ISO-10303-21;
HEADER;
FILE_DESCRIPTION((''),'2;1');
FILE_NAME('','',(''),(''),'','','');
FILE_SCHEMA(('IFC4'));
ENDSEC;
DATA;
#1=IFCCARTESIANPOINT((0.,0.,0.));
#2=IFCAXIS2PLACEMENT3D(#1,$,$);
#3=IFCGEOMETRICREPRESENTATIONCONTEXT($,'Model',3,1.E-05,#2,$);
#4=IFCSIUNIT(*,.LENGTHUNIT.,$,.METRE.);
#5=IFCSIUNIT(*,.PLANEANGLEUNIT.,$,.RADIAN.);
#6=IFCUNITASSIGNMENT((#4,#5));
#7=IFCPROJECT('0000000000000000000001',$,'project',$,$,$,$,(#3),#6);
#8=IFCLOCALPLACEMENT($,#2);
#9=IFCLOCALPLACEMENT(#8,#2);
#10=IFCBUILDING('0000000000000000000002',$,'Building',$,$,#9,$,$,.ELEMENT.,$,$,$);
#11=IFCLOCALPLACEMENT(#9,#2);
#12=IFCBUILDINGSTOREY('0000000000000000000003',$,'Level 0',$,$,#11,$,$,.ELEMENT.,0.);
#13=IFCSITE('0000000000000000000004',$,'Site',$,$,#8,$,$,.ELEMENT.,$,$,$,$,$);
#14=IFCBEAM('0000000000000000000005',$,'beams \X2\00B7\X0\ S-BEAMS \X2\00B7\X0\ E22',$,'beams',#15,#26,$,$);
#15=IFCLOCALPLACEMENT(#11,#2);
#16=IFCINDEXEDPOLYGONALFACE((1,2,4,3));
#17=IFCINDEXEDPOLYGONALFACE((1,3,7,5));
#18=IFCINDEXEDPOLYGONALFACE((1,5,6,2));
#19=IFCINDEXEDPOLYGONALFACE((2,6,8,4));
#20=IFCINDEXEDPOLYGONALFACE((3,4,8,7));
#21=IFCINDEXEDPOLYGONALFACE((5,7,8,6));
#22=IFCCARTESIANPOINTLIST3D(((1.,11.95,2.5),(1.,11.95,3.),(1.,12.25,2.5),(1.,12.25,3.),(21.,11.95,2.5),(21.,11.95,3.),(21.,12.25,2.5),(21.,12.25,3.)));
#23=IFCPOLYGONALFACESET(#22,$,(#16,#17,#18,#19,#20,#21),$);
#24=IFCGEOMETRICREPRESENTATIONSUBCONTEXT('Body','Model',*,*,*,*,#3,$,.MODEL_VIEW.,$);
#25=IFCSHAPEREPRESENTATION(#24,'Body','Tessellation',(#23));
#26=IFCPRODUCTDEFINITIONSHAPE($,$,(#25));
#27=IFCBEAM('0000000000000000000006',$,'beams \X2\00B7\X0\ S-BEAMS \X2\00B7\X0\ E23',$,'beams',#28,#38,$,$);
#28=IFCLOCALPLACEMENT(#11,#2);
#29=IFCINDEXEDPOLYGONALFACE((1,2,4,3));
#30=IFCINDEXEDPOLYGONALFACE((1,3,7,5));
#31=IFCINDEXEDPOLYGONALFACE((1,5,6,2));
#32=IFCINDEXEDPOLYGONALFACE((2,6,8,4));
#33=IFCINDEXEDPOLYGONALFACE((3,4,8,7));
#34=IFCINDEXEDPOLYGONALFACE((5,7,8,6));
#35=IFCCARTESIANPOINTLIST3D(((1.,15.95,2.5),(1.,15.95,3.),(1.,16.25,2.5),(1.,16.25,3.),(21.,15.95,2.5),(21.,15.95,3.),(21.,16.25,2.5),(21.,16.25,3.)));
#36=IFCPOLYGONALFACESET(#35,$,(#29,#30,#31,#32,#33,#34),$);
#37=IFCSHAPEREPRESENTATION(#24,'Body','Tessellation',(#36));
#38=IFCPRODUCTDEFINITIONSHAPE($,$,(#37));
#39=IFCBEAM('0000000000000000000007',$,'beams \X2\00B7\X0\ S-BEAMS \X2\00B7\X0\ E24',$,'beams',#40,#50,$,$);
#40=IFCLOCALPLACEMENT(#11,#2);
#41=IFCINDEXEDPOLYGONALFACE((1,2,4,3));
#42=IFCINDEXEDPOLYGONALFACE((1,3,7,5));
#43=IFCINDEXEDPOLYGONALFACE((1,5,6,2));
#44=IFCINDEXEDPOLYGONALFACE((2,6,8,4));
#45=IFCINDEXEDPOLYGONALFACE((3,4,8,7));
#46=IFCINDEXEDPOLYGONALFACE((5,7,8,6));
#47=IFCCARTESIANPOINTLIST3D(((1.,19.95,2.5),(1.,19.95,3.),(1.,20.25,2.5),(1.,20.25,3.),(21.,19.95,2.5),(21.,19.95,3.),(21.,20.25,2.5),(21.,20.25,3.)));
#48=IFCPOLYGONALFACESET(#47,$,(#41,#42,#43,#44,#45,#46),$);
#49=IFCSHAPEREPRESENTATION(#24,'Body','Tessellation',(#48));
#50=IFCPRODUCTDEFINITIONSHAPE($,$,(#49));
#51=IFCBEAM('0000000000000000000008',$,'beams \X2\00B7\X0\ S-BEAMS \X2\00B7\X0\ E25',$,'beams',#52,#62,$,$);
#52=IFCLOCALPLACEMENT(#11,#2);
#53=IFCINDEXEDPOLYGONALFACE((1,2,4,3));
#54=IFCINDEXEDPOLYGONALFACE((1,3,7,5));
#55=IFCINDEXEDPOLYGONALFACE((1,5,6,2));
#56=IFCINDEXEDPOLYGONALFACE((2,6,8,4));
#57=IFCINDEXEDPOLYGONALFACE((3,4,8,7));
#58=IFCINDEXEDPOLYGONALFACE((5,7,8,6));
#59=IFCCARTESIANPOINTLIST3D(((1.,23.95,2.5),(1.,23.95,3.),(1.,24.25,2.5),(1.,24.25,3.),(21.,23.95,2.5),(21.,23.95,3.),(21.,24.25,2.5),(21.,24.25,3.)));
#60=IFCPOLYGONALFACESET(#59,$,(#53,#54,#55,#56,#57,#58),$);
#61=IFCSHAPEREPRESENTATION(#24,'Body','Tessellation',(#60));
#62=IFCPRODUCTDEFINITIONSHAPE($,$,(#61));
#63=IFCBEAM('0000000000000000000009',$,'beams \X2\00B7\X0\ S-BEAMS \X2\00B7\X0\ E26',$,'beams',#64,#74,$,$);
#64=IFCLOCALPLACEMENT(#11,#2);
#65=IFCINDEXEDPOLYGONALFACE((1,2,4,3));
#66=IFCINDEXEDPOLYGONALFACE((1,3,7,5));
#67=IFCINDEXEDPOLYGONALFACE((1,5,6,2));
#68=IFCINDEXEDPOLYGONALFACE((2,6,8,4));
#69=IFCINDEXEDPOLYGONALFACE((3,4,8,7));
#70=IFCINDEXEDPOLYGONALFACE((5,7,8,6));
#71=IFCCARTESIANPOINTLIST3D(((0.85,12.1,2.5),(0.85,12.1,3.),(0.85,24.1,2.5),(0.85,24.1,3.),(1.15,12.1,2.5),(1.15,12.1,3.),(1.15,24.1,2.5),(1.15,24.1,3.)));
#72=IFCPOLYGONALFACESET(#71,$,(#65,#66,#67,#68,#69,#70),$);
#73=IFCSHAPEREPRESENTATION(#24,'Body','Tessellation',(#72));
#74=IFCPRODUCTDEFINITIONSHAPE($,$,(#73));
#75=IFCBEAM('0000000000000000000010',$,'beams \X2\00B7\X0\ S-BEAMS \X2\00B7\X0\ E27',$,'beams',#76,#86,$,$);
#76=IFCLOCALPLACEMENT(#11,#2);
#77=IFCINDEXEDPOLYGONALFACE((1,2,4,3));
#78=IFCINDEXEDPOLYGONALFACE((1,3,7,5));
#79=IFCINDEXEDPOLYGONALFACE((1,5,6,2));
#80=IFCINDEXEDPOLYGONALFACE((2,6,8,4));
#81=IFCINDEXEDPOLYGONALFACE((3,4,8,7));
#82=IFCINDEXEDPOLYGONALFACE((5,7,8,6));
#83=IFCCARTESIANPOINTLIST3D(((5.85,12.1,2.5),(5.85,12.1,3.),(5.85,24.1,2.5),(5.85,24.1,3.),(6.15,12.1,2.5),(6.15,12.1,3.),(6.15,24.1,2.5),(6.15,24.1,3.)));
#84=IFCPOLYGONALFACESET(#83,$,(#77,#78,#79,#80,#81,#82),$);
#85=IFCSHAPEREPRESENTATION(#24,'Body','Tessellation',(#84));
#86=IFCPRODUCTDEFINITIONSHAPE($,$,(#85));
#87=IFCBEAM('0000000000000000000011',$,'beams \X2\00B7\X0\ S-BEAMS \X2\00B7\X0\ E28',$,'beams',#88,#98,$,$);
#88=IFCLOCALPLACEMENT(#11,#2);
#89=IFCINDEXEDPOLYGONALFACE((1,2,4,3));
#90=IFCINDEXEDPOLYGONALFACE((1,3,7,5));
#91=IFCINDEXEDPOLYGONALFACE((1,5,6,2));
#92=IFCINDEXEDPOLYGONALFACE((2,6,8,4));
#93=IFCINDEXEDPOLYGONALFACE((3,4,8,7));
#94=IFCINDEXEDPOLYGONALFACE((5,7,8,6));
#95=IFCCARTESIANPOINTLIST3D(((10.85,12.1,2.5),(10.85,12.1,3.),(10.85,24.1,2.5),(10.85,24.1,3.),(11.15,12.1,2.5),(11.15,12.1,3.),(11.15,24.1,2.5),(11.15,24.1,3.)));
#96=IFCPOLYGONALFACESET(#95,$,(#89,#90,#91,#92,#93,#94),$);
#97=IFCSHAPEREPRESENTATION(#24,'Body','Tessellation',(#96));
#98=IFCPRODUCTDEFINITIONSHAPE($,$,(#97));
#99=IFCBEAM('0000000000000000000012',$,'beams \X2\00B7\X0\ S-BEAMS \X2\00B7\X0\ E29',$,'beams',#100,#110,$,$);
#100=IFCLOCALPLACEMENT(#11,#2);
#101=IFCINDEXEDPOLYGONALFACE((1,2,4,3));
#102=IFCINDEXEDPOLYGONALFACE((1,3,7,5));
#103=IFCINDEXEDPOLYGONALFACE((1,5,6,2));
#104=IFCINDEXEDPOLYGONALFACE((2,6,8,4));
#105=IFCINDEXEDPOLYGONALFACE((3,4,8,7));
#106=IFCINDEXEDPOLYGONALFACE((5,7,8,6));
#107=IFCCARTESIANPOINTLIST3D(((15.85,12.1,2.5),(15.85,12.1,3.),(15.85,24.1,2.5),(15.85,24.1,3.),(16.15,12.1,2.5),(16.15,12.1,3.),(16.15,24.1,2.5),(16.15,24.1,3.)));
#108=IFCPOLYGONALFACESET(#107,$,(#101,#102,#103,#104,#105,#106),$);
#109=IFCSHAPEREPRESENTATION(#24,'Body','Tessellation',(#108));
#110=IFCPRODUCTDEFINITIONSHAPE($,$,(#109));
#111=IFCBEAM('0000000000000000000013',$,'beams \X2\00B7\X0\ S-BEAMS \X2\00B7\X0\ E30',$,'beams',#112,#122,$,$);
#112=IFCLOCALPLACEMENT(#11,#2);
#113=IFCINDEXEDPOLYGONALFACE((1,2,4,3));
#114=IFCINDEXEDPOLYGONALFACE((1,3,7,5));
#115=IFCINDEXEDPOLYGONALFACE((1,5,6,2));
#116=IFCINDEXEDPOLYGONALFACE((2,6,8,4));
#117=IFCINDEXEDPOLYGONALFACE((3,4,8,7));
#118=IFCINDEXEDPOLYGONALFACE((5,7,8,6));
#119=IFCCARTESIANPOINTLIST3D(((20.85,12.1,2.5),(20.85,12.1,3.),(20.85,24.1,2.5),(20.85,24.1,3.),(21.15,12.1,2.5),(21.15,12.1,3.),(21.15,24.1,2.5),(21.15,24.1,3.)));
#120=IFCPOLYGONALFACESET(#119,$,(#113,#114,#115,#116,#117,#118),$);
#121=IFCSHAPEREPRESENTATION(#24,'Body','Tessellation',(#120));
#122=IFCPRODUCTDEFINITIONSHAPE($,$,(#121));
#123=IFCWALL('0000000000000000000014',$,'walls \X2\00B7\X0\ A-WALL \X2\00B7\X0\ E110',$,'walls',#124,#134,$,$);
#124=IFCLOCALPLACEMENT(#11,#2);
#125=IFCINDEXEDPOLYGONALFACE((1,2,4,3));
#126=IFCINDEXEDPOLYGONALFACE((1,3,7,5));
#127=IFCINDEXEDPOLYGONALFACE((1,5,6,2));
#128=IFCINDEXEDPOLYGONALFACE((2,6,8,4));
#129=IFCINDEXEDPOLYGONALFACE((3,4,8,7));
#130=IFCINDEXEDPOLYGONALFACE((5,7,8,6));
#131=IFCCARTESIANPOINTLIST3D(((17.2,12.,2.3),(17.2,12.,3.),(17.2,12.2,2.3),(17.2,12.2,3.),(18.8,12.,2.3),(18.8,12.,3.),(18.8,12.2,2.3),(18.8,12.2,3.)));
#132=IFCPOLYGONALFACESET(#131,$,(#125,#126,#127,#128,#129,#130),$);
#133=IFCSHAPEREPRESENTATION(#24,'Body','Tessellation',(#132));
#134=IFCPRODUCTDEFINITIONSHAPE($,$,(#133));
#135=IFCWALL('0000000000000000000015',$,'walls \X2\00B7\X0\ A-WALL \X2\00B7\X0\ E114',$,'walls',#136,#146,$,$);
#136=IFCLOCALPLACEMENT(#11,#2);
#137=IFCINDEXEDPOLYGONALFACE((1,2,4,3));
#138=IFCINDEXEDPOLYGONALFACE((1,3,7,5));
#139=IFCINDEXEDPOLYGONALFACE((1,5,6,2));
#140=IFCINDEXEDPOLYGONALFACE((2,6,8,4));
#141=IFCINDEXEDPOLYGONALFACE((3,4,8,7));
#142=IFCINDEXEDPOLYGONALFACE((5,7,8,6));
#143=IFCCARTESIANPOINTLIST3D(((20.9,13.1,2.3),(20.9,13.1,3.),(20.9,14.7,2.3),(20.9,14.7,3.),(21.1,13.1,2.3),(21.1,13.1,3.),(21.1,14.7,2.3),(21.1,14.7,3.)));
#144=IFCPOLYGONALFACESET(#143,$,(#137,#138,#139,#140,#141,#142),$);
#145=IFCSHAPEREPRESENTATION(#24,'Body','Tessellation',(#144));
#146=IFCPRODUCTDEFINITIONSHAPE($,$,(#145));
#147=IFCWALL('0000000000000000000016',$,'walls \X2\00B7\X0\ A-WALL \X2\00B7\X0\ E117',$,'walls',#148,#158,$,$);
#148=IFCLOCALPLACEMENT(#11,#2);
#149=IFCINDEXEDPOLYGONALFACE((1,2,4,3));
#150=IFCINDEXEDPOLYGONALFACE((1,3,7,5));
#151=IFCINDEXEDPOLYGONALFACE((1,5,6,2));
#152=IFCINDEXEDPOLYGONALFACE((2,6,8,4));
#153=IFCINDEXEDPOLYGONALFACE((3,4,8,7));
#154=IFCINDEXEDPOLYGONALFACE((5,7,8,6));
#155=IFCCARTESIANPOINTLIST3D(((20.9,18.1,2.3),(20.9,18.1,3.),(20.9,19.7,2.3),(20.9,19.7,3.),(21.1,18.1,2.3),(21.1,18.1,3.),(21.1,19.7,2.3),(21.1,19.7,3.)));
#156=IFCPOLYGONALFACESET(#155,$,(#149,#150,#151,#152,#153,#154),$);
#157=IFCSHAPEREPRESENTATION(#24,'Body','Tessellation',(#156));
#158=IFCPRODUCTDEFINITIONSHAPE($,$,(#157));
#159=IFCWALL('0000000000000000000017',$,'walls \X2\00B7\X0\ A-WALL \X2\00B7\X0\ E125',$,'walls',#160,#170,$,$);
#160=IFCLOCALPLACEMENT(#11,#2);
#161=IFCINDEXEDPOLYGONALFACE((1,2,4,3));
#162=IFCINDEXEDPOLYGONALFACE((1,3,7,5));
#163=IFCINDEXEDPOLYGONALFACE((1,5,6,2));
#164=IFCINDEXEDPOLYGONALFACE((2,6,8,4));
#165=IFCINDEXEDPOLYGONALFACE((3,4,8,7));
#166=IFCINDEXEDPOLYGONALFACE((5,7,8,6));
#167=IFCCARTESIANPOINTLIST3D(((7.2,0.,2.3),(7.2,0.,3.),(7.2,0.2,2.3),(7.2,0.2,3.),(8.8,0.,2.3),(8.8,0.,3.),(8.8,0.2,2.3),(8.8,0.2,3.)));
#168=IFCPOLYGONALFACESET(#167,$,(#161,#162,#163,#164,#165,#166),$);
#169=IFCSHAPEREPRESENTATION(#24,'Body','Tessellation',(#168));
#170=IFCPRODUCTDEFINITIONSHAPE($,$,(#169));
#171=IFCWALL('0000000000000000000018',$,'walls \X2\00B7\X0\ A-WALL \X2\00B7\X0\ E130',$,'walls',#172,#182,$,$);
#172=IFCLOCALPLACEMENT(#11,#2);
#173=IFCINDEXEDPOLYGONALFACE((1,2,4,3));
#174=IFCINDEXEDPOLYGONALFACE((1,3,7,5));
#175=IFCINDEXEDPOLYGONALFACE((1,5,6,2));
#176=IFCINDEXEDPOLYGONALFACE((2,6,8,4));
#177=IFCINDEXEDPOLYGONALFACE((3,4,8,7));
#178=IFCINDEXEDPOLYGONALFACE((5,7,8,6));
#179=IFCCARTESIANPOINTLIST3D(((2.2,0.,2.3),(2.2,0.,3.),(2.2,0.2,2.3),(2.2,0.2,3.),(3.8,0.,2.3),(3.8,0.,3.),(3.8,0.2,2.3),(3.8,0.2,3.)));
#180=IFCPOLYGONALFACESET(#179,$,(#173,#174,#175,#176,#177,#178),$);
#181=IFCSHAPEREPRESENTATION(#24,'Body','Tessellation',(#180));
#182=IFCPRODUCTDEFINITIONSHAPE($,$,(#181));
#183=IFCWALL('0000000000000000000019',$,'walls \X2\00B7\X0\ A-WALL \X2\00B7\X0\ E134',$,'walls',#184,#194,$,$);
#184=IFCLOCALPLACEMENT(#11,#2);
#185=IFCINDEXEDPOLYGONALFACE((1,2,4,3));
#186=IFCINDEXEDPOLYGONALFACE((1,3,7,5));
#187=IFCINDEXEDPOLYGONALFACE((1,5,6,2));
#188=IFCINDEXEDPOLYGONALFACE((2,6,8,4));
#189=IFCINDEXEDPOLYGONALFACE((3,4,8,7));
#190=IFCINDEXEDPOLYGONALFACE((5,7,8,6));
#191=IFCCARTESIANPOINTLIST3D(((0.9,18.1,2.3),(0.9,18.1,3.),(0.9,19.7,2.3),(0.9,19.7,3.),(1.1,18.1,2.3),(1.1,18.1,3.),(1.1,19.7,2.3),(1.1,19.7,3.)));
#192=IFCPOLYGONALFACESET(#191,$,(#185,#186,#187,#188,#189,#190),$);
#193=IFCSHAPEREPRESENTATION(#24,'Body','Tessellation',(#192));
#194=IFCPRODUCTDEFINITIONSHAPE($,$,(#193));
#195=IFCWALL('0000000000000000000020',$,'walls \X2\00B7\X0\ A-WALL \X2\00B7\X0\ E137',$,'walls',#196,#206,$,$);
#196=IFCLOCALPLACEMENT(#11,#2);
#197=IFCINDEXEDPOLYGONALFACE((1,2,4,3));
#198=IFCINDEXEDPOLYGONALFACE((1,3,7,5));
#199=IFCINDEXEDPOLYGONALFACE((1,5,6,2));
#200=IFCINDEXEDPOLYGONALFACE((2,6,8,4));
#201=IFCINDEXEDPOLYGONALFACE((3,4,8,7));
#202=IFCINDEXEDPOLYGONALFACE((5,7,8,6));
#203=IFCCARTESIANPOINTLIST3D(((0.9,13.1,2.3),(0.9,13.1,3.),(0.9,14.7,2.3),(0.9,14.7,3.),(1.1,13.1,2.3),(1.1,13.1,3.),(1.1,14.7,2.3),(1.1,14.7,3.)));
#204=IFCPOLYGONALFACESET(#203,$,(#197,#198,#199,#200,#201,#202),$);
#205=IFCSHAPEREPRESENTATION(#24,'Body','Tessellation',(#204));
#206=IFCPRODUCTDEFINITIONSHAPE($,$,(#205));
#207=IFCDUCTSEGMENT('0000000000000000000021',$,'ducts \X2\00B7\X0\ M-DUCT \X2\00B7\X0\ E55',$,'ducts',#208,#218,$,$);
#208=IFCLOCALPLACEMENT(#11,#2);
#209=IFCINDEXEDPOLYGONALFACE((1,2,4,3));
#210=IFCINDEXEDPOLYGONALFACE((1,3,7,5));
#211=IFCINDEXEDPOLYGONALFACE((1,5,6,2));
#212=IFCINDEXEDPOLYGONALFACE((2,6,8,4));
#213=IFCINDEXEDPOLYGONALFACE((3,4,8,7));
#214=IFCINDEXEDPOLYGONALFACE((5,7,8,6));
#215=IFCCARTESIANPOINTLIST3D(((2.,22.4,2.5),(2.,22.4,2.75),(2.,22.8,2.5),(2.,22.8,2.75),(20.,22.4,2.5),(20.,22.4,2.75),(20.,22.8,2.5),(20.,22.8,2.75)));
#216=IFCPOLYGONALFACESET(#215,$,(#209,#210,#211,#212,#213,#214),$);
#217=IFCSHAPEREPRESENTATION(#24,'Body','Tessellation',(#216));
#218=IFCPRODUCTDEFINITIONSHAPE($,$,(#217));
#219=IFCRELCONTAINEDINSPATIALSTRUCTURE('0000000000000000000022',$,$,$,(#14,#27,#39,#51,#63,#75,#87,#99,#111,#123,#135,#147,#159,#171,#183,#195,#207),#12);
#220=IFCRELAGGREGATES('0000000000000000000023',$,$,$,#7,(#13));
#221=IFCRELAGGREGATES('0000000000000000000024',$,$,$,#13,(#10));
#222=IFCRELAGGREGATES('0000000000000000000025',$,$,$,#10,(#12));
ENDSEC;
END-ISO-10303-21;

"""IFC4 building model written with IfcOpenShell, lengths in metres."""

from ifc_helpers import new_model, si_unit, frame, origin, place, context, subcontext, project, spatial, polyline, outline, extrude, element, save


model = new_model("IFC4")

# Units and contexts
model_context = context("Model", 3, precision=1e-05, world=origin())
body_context = subcontext(model_context, "Body", "Model", "MODEL_VIEW")
ifc_project = project(units=[si_unit("LENGTHUNIT", "METRE"), si_unit("PLANEANGLEUNIT", "RADIAN")], contexts=[model_context])

# Site, building, storey
site_placement = place(None, origin())
site = spatial("IfcSite", under=ifc_project, at=site_placement, Name="Site", CompositionType="ELEMENT")
building_placement = place(site_placement, origin())
building = spatial("IfcBuilding", under=site, at=building_placement, Name="Building", CompositionType="ELEMENT")
storey_placement = place(building_placement, origin())
storey = spatial("IfcBuildingStorey", under=building, at=storey_placement, Name="Level 0", CompositionType="ELEMENT", Elevation=0.0)

# Beams
beam_1_placement = place(storey_placement, frame((0.0, 0.0, 2.5)))
element("IfcBeam", 1, at=beam_1_placement, inside=storey, Name="beams · S-BEAMS · E22", ObjectType="beams", context=body_context, shape_type="SweptSolid", body=[
    extrude(outline(polyline([(1.0, 11.95), (21.0, 11.95), (21.0, 12.25), (1.0, 12.25), (1.0, 11.95)])), origin(), (0.0, 0.0, 1.0), 0.5),
])
beam_2_placement = place(storey_placement, frame((0.0, 0.0, 2.5)))
element("IfcBeam", 2, at=beam_2_placement, inside=storey, Name="beams · S-BEAMS · E23", ObjectType="beams", context=body_context, shape_type="SweptSolid", body=[
    extrude(outline(polyline([(1.0, 15.95), (21.0, 15.95), (21.0, 16.25), (1.0, 16.25), (1.0, 15.95)])), origin(), (0.0, 0.0, 1.0), 0.5),
])
beam_3_placement = place(storey_placement, frame((0.0, 0.0, 2.5)))
element("IfcBeam", 3, at=beam_3_placement, inside=storey, Name="beams · S-BEAMS · E24", ObjectType="beams", context=body_context, shape_type="SweptSolid", body=[
    extrude(outline(polyline([(1.0, 19.95), (21.0, 19.95), (21.0, 20.25), (1.0, 20.25), (1.0, 19.95)])), origin(), (0.0, 0.0, 1.0), 0.5),
])
beam_4_placement = place(storey_placement, frame((0.0, 0.0, 2.5)))
element("IfcBeam", 4, at=beam_4_placement, inside=storey, Name="beams · S-BEAMS · E25", ObjectType="beams", context=body_context, shape_type="SweptSolid", body=[
    extrude(outline(polyline([(1.0, 23.95), (21.0, 23.95), (21.0, 24.25), (1.0, 24.25), (1.0, 23.95)])), origin(), (0.0, 0.0, 1.0), 0.5),
])
beam_5_placement = place(storey_placement, frame((0.0, 0.0, 2.5)))
element("IfcBeam", 5, at=beam_5_placement, inside=storey, Name="beams · S-BEAMS · E26", ObjectType="beams", context=body_context, shape_type="SweptSolid", body=[
    extrude(outline(polyline([(1.15, 12.1), (1.15, 24.1), (0.85, 24.1), (0.85, 12.1), (1.15, 12.1)])), origin(), (0.0, 0.0, 1.0), 0.5),
])
beam_6_placement = place(storey_placement, frame((0.0, 0.0, 2.5)))
element("IfcBeam", 6, at=beam_6_placement, inside=storey, Name="beams · S-BEAMS · E27", ObjectType="beams", context=body_context, shape_type="SweptSolid", body=[
    extrude(outline(polyline([(6.15, 12.1), (6.15, 24.1), (5.85, 24.1), (5.85, 12.1), (6.15, 12.1)])), origin(), (0.0, 0.0, 1.0), 0.5),
])
beam_7_placement = place(storey_placement, frame((0.0, 0.0, 2.5)))
element("IfcBeam", 7, at=beam_7_placement, inside=storey, Name="beams · S-BEAMS · E28", ObjectType="beams", context=body_context, shape_type="SweptSolid", body=[
    extrude(outline(polyline([(11.15, 12.1), (11.15, 24.1), (10.85, 24.1), (10.85, 12.1), (11.15, 12.1)])), origin(), (0.0, 0.0, 1.0), 0.5),
])
beam_8_placement = place(storey_placement, frame((0.0, 0.0, 2.5)))
element("IfcBeam", 8, at=beam_8_placement, inside=storey, Name="beams · S-BEAMS · E29", ObjectType="beams", context=body_context, shape_type="SweptSolid", body=[
    extrude(outline(polyline([(16.15, 12.1), (16.15, 24.1), (15.85, 24.1), (15.85, 12.1), (16.15, 12.1)])), origin(), (0.0, 0.0, 1.0), 0.5),
])
beam_9_placement = place(storey_placement, frame((0.0, 0.0, 2.5)))
element("IfcBeam", 9, at=beam_9_placement, inside=storey, Name="beams · S-BEAMS · E30", ObjectType="beams", context=body_context, shape_type="SweptSolid", body=[
    extrude(outline(polyline([(21.15, 12.1), (21.15, 24.1), (20.85, 24.1), (20.85, 12.1), (21.15, 12.1)])), origin(), (0.0, 0.0, 1.0), 0.5),
])

# Walls
wall_1_placement = place(storey_placement, frame((0.0, 0.0, 2.3)))
element("IfcWall", 10, at=wall_1_placement, inside=storey, Name="walls · A-WALL · E110", ObjectType="walls", context=body_context, shape_type="SweptSolid", body=[
    extrude(outline(polyline([(17.2, 12.0), (18.8, 12.0), (18.8, 12.2), (17.2, 12.2), (17.2, 12.0)])), origin(), (0.0, 0.0, 1.0), 0.7),
])
wall_2_placement = place(storey_placement, frame((0.0, 0.0, 2.3)))
element("IfcWall", 11, at=wall_2_placement, inside=storey, Name="walls · A-WALL · E114", ObjectType="walls", context=body_context, shape_type="SweptSolid", body=[
    extrude(outline(polyline([(21.1, 13.1), (21.1, 14.7), (20.9, 14.7), (20.9, 13.1), (21.1, 13.1)])), origin(), (0.0, 0.0, 1.0), 0.7),
])
wall_3_placement = place(storey_placement, frame((0.0, 0.0, 2.3)))
element("IfcWall", 12, at=wall_3_placement, inside=storey, Name="walls · A-WALL · E117", ObjectType="walls", context=body_context, shape_type="SweptSolid", body=[
    extrude(outline(polyline([(21.1, 18.1), (21.1, 19.7), (20.9, 19.7), (20.9, 18.1), (21.1, 18.1)])), origin(), (0.0, 0.0, 1.0), 0.7),
])
wall_4_placement = place(storey_placement, frame((0.0, 0.0, 2.3)))
element("IfcWall", 13, at=wall_4_placement, inside=storey, Name="walls · A-WALL · E125", ObjectType="walls", context=body_context, shape_type="SweptSolid", body=[
    extrude(outline(polyline([(8.8, 0.2), (7.2, 0.2), (7.2, 0.0), (8.8, 0.0), (8.8, 0.2)])), origin(), (0.0, 0.0, 1.0), 0.7),
])
wall_5_placement = place(storey_placement, frame((0.0, 0.0, 2.3)))
element("IfcWall", 14, at=wall_5_placement, inside=storey, Name="walls · A-WALL · E130", ObjectType="walls", context=body_context, shape_type="SweptSolid", body=[
    extrude(outline(polyline([(3.8, 0.2), (2.2, 0.2), (2.2, 0.0), (3.8, 0.0), (3.8, 0.2)])), origin(), (0.0, 0.0, 1.0), 0.7),
])
wall_6_placement = place(storey_placement, frame((0.0, 0.0, 2.3)))
element("IfcWall", 15, at=wall_6_placement, inside=storey, Name="walls · A-WALL · E134", ObjectType="walls", context=body_context, shape_type="SweptSolid", body=[
    extrude(outline(polyline([(0.9, 19.7), (0.9, 18.1), (1.1, 18.1), (1.1, 19.7), (0.9, 19.7)])), origin(), (0.0, 0.0, 1.0), 0.7),
])
wall_7_placement = place(storey_placement, frame((0.0, 0.0, 2.3)))
element("IfcWall", 16, at=wall_7_placement, inside=storey, Name="walls · A-WALL · E137", ObjectType="walls", context=body_context, shape_type="SweptSolid", body=[
    extrude(outline(polyline([(0.9, 14.7), (0.9, 13.1), (1.1, 13.1), (1.1, 14.7), (0.9, 14.7)])), origin(), (0.0, 0.0, 1.0), 0.7),
])

# Duct segment
duct_segment_1_placement = place(storey_placement, frame((0.0, 0.0, 2.5)))
element("IfcDuctSegment", 17, at=duct_segment_1_placement, inside=storey, Name="ducts · M-DUCT · E55", ObjectType="ducts", context=body_context, shape_type="SweptSolid", body=[
    extrude(outline(polyline([(2.0, 22.4), (20.0, 22.4), (20.0, 22.8), (2.0, 22.8), (2.0, 22.4)])), origin(), (0.0, 0.0, 1.0), 0.25),
])

save(model, "model.ifc")
